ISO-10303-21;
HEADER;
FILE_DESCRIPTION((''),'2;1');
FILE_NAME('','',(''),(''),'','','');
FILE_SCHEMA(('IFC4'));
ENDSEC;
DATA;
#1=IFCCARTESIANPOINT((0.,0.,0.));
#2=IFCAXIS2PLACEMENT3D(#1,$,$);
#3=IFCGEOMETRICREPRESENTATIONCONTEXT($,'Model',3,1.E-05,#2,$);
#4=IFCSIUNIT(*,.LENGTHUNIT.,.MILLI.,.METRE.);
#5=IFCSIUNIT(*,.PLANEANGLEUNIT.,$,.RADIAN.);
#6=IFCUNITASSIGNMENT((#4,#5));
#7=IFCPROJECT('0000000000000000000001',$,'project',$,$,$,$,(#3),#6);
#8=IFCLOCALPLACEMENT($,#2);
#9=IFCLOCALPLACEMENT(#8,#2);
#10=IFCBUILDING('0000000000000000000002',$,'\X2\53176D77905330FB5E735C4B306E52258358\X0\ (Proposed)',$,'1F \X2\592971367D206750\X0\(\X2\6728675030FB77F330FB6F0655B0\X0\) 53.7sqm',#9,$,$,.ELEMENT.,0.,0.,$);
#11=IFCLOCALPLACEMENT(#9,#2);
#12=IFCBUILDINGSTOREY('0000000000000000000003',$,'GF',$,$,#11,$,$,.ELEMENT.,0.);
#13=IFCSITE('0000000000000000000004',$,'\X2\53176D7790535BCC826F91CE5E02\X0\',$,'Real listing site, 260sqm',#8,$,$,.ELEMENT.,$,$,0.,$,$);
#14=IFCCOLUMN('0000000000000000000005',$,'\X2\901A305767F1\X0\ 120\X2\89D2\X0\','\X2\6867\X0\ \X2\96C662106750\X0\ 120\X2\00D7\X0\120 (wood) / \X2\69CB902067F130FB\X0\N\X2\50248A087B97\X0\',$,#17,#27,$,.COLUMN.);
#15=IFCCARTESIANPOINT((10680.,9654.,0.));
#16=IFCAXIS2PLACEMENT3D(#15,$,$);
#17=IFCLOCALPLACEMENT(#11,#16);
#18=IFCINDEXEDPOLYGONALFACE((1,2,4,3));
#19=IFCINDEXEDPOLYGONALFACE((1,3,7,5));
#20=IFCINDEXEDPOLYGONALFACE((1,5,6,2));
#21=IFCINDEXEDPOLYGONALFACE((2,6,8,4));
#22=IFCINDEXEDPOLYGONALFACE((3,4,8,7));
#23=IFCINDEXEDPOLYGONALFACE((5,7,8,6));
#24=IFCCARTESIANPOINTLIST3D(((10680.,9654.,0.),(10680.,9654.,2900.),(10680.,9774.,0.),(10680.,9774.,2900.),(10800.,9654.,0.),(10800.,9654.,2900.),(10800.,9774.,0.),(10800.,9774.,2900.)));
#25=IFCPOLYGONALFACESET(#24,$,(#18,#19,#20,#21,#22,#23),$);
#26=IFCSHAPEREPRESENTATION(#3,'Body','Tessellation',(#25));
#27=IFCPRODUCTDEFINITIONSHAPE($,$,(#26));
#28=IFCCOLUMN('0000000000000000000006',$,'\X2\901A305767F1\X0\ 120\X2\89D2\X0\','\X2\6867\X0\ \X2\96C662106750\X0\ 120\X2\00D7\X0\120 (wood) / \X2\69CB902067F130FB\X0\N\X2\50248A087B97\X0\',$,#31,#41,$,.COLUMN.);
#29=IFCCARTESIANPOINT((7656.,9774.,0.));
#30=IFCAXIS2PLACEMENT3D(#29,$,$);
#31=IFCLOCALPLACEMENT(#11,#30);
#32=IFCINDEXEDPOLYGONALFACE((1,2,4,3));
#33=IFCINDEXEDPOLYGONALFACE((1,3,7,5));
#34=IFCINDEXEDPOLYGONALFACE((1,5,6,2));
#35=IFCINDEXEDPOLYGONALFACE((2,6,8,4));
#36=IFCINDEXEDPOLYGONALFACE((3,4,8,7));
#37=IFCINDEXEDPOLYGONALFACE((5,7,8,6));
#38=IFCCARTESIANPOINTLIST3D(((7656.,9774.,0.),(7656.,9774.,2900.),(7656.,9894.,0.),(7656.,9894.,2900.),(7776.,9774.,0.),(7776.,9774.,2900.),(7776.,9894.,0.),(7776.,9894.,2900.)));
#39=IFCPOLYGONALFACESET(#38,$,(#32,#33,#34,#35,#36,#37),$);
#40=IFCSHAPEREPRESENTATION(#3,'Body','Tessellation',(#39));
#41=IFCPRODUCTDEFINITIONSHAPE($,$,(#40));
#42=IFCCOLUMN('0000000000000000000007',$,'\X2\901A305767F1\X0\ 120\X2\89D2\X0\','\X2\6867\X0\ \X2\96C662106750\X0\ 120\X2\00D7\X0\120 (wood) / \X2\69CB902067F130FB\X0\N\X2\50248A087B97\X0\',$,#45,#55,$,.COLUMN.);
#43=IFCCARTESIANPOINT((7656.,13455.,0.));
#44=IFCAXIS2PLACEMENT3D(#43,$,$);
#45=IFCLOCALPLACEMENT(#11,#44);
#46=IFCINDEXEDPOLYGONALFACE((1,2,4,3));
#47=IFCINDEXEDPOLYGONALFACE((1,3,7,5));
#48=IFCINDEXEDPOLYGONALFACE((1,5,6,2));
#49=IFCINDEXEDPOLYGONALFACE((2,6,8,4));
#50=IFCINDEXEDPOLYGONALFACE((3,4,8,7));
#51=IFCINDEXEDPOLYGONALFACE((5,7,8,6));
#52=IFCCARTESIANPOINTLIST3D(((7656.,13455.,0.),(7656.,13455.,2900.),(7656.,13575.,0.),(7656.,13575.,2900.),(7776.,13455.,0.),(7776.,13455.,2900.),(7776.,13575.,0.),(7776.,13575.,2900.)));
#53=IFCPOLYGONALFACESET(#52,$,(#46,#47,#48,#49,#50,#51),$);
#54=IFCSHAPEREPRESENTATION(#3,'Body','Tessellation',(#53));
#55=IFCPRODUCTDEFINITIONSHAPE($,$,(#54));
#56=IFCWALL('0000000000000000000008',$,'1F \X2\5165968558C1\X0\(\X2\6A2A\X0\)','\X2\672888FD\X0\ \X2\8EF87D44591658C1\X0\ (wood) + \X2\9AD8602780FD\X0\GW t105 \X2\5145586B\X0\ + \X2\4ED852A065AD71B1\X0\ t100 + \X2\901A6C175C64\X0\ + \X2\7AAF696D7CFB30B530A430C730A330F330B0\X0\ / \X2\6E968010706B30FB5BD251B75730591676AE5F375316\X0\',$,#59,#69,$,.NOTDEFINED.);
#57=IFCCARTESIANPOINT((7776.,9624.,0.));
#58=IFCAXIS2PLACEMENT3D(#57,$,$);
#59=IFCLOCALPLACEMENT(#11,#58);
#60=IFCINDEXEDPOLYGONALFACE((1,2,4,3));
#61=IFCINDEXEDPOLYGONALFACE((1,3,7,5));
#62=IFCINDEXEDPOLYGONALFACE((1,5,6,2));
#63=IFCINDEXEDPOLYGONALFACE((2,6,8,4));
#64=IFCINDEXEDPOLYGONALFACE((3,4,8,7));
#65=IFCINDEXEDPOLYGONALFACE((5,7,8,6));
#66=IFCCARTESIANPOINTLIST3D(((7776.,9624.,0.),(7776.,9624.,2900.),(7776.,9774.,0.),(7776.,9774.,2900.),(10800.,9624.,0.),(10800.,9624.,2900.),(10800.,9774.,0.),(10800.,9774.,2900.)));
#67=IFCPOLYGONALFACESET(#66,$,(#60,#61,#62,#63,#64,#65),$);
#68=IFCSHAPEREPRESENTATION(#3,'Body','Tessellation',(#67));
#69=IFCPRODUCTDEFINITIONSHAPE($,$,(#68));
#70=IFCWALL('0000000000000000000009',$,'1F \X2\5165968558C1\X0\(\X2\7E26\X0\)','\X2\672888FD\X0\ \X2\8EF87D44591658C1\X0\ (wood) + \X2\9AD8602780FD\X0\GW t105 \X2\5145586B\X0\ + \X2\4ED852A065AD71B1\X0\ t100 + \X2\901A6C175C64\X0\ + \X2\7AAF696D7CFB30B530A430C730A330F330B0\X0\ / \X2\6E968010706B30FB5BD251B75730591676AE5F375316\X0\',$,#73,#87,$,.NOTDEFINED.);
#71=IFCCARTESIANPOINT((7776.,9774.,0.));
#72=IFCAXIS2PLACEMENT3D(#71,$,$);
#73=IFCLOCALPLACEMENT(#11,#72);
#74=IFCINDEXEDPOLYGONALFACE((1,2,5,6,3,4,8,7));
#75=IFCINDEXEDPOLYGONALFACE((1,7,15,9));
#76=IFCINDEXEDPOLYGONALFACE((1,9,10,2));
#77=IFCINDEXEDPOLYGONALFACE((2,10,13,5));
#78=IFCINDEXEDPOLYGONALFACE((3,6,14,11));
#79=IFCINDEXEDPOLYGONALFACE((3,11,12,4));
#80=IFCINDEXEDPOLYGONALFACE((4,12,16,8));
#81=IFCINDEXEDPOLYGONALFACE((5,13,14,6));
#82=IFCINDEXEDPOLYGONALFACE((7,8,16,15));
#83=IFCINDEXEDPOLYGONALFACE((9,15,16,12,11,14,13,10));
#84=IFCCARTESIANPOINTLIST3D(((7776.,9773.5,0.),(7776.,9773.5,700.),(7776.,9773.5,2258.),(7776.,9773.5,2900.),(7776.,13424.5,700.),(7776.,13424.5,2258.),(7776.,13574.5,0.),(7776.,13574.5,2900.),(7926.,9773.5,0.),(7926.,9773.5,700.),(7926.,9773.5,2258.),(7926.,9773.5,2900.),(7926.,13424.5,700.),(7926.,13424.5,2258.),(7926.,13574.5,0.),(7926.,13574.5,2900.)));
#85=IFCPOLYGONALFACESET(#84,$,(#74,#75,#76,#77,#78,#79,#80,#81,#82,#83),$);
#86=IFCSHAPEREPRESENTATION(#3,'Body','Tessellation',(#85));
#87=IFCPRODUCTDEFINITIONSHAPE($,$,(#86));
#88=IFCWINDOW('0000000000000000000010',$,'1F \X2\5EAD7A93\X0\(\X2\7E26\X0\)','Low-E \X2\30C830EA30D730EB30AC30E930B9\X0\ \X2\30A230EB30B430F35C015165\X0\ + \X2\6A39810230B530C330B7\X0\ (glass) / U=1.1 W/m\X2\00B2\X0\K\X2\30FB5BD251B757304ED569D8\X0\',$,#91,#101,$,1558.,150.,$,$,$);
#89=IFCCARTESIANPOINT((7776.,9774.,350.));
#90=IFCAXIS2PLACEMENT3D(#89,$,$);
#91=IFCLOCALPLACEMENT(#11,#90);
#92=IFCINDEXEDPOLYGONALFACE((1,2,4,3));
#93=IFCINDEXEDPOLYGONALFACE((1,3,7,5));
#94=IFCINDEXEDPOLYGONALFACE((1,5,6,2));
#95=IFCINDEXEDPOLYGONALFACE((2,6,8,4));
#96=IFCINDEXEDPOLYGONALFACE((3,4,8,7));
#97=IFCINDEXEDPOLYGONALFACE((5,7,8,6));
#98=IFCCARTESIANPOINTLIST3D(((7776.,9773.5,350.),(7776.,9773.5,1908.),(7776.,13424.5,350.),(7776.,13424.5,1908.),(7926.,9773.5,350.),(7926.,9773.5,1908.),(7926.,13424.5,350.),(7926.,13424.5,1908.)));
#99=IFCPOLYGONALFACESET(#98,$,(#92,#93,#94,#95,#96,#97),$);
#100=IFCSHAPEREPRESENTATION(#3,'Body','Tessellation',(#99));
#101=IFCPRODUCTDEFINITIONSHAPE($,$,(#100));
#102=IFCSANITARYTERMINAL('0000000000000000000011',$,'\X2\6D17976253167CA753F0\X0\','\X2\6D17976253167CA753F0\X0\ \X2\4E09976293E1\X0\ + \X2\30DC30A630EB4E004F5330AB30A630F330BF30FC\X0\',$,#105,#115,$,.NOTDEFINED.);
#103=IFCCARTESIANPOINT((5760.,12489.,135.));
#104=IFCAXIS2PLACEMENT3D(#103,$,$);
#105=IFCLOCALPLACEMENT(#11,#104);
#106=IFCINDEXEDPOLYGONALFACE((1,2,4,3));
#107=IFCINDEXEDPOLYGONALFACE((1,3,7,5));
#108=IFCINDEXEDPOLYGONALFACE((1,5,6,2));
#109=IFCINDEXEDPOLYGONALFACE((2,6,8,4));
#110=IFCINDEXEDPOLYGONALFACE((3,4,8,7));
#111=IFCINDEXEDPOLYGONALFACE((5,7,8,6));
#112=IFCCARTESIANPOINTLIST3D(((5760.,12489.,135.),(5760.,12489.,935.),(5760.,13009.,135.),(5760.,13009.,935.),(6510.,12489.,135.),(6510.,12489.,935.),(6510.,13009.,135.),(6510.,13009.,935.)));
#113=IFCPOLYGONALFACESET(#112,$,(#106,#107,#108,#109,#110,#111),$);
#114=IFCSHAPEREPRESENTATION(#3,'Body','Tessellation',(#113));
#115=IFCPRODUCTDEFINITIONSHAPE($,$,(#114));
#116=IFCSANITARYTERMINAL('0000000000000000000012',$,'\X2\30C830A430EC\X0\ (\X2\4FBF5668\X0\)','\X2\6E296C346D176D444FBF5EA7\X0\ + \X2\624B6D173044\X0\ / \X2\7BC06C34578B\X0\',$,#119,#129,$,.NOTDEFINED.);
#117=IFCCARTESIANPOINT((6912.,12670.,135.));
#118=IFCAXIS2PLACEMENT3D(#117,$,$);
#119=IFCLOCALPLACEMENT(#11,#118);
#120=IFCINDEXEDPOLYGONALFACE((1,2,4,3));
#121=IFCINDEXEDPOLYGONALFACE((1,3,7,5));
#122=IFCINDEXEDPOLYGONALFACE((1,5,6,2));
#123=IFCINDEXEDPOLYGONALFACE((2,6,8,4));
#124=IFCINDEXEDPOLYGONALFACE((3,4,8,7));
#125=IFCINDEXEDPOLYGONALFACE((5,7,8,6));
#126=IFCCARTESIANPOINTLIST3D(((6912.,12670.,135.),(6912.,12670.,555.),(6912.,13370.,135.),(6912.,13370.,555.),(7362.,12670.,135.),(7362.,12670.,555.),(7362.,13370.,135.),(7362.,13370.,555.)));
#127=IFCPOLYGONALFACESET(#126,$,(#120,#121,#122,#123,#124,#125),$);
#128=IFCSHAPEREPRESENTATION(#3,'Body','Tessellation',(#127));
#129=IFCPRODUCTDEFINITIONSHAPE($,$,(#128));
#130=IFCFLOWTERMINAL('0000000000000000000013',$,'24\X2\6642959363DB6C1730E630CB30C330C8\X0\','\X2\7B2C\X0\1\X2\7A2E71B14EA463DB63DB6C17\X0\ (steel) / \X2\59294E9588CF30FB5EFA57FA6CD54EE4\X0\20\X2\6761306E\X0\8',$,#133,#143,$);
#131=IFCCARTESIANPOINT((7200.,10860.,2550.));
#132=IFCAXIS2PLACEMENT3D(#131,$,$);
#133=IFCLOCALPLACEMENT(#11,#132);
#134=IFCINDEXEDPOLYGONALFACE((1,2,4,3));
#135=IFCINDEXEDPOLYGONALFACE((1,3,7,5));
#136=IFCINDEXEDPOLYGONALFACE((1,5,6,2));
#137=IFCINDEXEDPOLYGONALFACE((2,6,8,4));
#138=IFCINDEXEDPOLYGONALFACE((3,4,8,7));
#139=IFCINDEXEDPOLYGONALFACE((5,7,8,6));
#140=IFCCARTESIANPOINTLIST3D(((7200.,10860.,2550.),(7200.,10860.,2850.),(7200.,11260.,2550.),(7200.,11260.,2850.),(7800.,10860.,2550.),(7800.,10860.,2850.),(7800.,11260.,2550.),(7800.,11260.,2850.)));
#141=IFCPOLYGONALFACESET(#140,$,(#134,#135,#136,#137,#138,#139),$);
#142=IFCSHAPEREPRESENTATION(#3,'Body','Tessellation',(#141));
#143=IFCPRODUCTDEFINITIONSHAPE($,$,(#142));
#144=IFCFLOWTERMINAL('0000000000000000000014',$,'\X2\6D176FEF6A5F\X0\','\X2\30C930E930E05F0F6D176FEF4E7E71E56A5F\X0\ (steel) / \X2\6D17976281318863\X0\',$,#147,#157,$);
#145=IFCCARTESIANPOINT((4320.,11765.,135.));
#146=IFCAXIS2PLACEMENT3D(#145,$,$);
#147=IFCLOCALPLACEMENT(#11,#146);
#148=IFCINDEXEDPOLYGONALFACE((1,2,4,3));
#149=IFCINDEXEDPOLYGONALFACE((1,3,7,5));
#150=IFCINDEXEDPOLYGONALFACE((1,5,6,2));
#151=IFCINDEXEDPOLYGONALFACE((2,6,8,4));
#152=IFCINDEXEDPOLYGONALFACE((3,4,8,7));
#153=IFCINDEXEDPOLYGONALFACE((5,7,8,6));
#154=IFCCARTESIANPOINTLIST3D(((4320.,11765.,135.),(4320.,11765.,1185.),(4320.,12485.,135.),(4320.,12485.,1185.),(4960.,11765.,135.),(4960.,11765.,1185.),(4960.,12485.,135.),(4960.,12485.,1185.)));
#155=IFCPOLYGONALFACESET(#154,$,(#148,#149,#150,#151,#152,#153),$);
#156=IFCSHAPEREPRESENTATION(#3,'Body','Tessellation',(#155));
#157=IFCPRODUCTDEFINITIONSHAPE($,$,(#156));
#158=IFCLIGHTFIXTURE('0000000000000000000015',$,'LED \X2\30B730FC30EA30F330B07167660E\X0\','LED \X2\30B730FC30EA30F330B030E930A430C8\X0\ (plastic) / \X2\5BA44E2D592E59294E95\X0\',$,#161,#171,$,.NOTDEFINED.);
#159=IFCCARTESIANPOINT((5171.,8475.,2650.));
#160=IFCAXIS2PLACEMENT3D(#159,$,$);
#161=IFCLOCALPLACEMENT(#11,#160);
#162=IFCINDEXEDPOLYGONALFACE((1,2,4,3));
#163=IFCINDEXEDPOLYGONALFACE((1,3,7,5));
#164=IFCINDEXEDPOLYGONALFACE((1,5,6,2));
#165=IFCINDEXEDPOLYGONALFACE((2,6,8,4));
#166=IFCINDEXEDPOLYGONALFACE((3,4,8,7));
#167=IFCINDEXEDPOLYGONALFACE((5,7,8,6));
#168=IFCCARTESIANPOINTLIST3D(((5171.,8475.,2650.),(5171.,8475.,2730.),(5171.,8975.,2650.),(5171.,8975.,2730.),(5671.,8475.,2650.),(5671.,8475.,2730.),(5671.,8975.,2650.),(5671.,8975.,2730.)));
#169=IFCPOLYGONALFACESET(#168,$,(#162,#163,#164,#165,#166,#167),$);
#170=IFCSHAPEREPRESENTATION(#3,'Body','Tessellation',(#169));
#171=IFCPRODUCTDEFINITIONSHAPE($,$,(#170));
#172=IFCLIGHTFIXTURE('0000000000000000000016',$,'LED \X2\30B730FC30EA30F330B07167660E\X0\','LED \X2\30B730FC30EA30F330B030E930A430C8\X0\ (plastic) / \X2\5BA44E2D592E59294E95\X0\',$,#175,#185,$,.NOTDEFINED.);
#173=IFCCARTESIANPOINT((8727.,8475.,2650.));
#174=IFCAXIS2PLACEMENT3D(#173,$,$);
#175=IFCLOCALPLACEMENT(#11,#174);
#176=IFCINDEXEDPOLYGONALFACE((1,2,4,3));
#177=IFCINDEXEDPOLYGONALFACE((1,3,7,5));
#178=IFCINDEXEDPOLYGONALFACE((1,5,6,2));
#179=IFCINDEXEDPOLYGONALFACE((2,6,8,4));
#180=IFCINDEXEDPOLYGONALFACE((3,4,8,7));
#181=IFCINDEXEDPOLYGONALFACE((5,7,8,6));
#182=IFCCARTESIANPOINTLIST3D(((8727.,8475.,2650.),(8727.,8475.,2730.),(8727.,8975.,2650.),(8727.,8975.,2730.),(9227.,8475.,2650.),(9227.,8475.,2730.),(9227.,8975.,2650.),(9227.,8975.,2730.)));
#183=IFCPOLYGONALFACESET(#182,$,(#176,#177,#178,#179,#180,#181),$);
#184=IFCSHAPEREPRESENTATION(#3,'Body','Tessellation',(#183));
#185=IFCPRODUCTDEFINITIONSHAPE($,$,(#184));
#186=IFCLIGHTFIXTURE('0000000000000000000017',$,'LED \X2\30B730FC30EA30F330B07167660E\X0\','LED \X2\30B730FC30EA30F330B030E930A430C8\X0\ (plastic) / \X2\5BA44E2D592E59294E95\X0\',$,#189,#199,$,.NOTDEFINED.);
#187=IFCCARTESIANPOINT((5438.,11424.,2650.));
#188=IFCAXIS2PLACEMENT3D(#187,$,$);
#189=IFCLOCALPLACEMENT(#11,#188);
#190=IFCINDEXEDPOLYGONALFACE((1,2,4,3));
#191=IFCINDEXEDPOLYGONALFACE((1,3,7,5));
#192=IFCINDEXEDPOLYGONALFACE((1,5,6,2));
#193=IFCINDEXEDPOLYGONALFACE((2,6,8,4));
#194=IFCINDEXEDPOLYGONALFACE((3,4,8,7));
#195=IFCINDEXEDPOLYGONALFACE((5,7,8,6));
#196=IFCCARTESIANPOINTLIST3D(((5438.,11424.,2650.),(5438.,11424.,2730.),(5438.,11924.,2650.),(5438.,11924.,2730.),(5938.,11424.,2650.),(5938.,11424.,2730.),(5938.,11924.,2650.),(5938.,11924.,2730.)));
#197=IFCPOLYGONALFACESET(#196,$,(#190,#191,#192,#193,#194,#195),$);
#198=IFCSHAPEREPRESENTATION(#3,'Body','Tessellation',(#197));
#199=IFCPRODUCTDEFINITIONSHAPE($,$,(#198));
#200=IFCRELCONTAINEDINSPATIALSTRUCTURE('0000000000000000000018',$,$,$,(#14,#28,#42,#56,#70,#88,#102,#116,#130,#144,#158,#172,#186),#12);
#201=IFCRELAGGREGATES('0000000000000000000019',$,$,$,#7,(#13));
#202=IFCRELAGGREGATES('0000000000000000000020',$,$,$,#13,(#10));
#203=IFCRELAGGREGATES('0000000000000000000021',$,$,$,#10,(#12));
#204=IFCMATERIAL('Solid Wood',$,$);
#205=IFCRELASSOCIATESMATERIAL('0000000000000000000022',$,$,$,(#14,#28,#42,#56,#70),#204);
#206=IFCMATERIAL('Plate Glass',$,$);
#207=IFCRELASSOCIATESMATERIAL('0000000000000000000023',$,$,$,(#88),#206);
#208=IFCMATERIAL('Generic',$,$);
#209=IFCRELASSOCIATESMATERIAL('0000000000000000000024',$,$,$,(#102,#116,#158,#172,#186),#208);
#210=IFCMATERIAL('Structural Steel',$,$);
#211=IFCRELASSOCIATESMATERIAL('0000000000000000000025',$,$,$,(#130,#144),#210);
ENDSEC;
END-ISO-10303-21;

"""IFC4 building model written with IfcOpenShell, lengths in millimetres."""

from ifc_helpers import new_model, si_unit, frame, frame_2d, origin, place, context, project, spatial, rectangle, extrude, material, element, fill, save


model = new_model("IFC4")

# Units and contexts
model_context = context("Model", 3, precision=1e-05, world=origin())
ifc_project = project(units=[si_unit("LENGTHUNIT", "METRE", prefix="MILLI"), si_unit("PLANEANGLEUNIT", "RADIAN")], contexts=[model_context])

# Site, building, storey
site_placement = place(None, origin())
site = spatial("IfcSite", under=ifc_project, at=site_placement, Name="北海道富良野市", ObjectType="Real listing site, 260sqm", CompositionType="ELEMENT", RefElevation=0.0)
building_placement = place(site_placement, origin())
building = spatial("IfcBuilding", under=site, at=building_placement, Name="北海道・平屋の別荘 (Proposed)", ObjectType="1F 天然素材(木材・石・漆喰) 53.7sqm", CompositionType="ELEMENT", ElevationOfRefHeight=0.0, ElevationOfTerrain=0.0)
storey_placement = place(building_placement, origin())
storey = spatial("IfcBuildingStorey", under=building, at=storey_placement, Name="GF", CompositionType="ELEMENT", Elevation=0.0)

# Columns
ifc_material_1 = material(Name="Solid Wood")
column_1_placement = place(storey_placement, frame((10680.0, 9654.0, 0.0)))
element("IfcColumn", 1, at=column_1_placement, inside=storey, material=ifc_material_1, Name="通し柱 120角", Description="桧 集成材 120×120 (wood) / 構造柱・N値計算", PredefinedType="COLUMN", context=model_context, shape_type="SweptSolid", body=[
    extrude(rectangle(XDim=120.0, YDim=120.0, at=frame_2d((60.0, 60.0))), frame((10680.0, 9654.0, 0.0)), (0.0, 0.0, 1.0), 2900.0),
])
column_2_placement = place(storey_placement, frame((7656.0, 9774.0, 0.0)))
element("IfcColumn", 2, at=column_2_placement, inside=storey, material=ifc_material_1, Name="通し柱 120角", Description="桧 集成材 120×120 (wood) / 構造柱・N値計算", PredefinedType="COLUMN", context=model_context, shape_type="SweptSolid", body=[
    extrude(rectangle(XDim=120.0, YDim=120.0, at=frame_2d((60.0, 60.0))), frame((7656.0, 9774.0, 0.0)), (0.0, 0.0, 1.0), 2900.0),
])
column_3_placement = place(storey_placement, frame((7656.0, 13455.0, 0.0)))
element("IfcColumn", 3, at=column_3_placement, inside=storey, material=ifc_material_1, Name="通し柱 120角", Description="桧 集成材 120×120 (wood) / 構造柱・N値計算", PredefinedType="COLUMN", context=model_context, shape_type="SweptSolid", body=[
    extrude(rectangle(XDim=120.0, YDim=120.0, at=frame_2d((60.0, 60.0))), frame((7656.0, 13455.0, 0.0)), (0.0, 0.0, 1.0), 2900.0),
])

# Wall
wall_1_placement = place(storey_placement, frame((7776.0, 9624.0, 0.0)))
element("IfcWall", 4, at=wall_1_placement, inside=storey, material=ifc_material_1, Name="1F 入隅壁(横)", Description="木製 軸組外壁 (wood) + 高性能GW t105 充填 + 付加断熱 t100 + 通気層 + 窯業系サイディング / 準耐火・寒冷地外皮強化", PredefinedType="NOTDEFINED", context=model_context, shape_type="SweptSolid", body=[
    extrude(rectangle(XDim=3024.0, YDim=150.0, at=frame_2d((1512.0, 75.0))), frame((7776.0, 9624.0, 0.0)), (0.0, 0.0, 1.0), 2900.0),
])

# Wall, opening, window
wall_2_placement = place(storey_placement, frame((7776.0, 9774.0, 0.0)))
wall_2 = element("IfcWall", 5, at=wall_2_placement, inside=storey, material=ifc_material_1, Name="1F 入隅壁(縦)", Description="木製 軸組外壁 (wood) + 高性能GW t105 充填 + 付加断熱 t100 + 通気層 + 窯業系サイディング / 準耐火・寒冷地外皮強化", PredefinedType="NOTDEFINED", context=model_context, shape_type="SweptSolid", body=[
    extrude(rectangle(XDim=150.0, YDim=3801.0, at=frame_2d((75.0, 1900.0))), frame((7776.0, 9774.0, 0.0)), (0.0, 0.0, 1.0), 2900.0),
])
opening_placement = place(storey_placement, frame((7776.0, 9774.0, 350.0)))
opening = element("IfcOpeningElement", 6, at=opening_placement, cuts=wall_2, PredefinedType="NOTDEFINED", context=model_context, shape_type="SweptSolid", body=[
    extrude(rectangle(XDim=150.0, YDim=3651.0, at=frame_2d((75.0, 1825.0))), frame((7776.0, 9774.0, 350.0)), (0.0, 0.0, 1.0), 1558.0),
])
ifc_material_2 = material(Name="Plate Glass")
window_placement = place(storey_placement, frame((7776.0, 9774.0, 350.0)))
window = element("IfcWindow", 7, at=window_placement, inside=storey, material=ifc_material_2, Name="1F 庭窓(縦)", Description="Low-E トリプルガラス アルゴン封入 + 樹脂サッシ (glass) / U=1.1 W/m²K・寒冷地仕様", OverallHeight=1558.0, OverallWidth=150.0, context=model_context, shape_type="SweptSolid", body=[
    extrude(rectangle(XDim=150.0, YDim=3651.0, at=frame_2d((75.0, 1825.0))), frame((7776.0, 9774.0, 350.0)), (0.0, 0.0, 1.0), 1558.0),
])
fill(opening, window)

# Sanitary terminals
ifc_material_3 = material(Name="Generic")
sanitary_terminal_1_placement = place(storey_placement, frame((5760.0, 12489.0, 135.0)))
element("IfcSanitaryTerminal", 8, at=sanitary_terminal_1_placement, inside=storey, material=ifc_material_3, Name="洗面化粧台", Description="洗面化粧台 三面鏡 + ボウル一体カウンター", PredefinedType="NOTDEFINED", context=model_context, shape_type="SweptSolid", body=[
    extrude(rectangle(XDim=750.0, YDim=520.0, at=frame_2d((375.0, 260.0))), frame((5760.0, 12489.0, 135.0)), (0.0, 0.0, 1.0), 800.0),
])
sanitary_terminal_2_placement = place(storey_placement, frame((6912.0, 12670.0, 135.0)))
element("IfcSanitaryTerminal", 9, at=sanitary_terminal_2_placement, inside=storey, material=ifc_material_3, Name="トイレ (便器)", Description="温水洗浄便座 + 手洗い / 節水型", PredefinedType="NOTDEFINED", context=model_context, shape_type="SweptSolid", body=[
    extrude(rectangle(XDim=450.0, YDim=700.0, at=frame_2d((225.0, 350.0))), frame((6912.0, 12670.0, 135.0)), (0.0, 0.0, 1.0), 420.0),
])

# Flow terminals
ifc_material_4 = material(Name="Structural Steel")
flow_terminal_1_placement = place(storey_placement, frame((7200.0, 10860.0, 2550.0)))
element("IfcFlowTerminal", 10, at=flow_terminal_1_placement, inside=storey, material=ifc_material_4, Name="24時間換気ユニット", Description="第1種熱交換換気 (steel) / 天井裏・建基法令20条の8", context=model_context, shape_type="SweptSolid", body=[
    extrude(rectangle(XDim=600.0, YDim=400.0, at=frame_2d((300.0, 200.0))), frame((7200.0, 10860.0, 2550.0)), (0.0, 0.0, 1.0), 300.0),
])
flow_terminal_2_placement = place(storey_placement, frame((4320.0, 11765.0, 135.0)))
element("IfcFlowTerminal", 11, at=flow_terminal_2_placement, inside=storey, material=ifc_material_4, Name="洗濯機", Description="ドラム式洗濯乾燥機 (steel) / 洗面脱衣", context=model_context, shape_type="SweptSolid", body=[
    extrude(rectangle(XDim=640.0, YDim=720.0, at=frame_2d((320.0, 360.0))), frame((4320.0, 11765.0, 135.0)), (0.0, 0.0, 1.0), 1050.0),
])

# Light fixtures
light_fixture_1_placement = place(storey_placement, frame((5171.0, 8475.0, 2650.0)))
element("IfcLightFixture", 12, at=light_fixture_1_placement, inside=storey, material=ifc_material_3, Name="LED シーリング照明", Description="LED シーリングライト (plastic) / 室中央天井", PredefinedType="NOTDEFINED", context=model_context, shape_type="SweptSolid", body=[
    extrude(rectangle(XDim=500.0, YDim=500.0, at=frame_2d((250.0, 250.0))), frame((5171.0, 8475.0, 2650.0)), (0.0, 0.0, 1.0), 80.0),
])
light_fixture_2_placement = place(storey_placement, frame((8727.0, 8475.0, 2650.0)))
element("IfcLightFixture", 13, at=light_fixture_2_placement, inside=storey, material=ifc_material_3, Name="LED シーリング照明", Description="LED シーリングライト (plastic) / 室中央天井", PredefinedType="NOTDEFINED", context=model_context, shape_type="SweptSolid", body=[
    extrude(rectangle(XDim=500.0, YDim=500.0, at=frame_2d((250.0, 250.0))), frame((8727.0, 8475.0, 2650.0)), (0.0, 0.0, 1.0), 80.0),
])
light_fixture_3_placement = place(storey_placement, frame((5438.0, 11424.0, 2650.0)))
element("IfcLightFixture", 14, at=light_fixture_3_placement, inside=storey, material=ifc_material_3, Name="LED シーリング照明", Description="LED シーリングライト (plastic) / 室中央天井", PredefinedType="NOTDEFINED", context=model_context, shape_type="SweptSolid", body=[
    extrude(rectangle(XDim=500.0, YDim=500.0, at=frame_2d((250.0, 250.0))), frame((5438.0, 11424.0, 2650.0)), (0.0, 0.0, 1.0), 80.0),
])

save(model, "model.ifc")
